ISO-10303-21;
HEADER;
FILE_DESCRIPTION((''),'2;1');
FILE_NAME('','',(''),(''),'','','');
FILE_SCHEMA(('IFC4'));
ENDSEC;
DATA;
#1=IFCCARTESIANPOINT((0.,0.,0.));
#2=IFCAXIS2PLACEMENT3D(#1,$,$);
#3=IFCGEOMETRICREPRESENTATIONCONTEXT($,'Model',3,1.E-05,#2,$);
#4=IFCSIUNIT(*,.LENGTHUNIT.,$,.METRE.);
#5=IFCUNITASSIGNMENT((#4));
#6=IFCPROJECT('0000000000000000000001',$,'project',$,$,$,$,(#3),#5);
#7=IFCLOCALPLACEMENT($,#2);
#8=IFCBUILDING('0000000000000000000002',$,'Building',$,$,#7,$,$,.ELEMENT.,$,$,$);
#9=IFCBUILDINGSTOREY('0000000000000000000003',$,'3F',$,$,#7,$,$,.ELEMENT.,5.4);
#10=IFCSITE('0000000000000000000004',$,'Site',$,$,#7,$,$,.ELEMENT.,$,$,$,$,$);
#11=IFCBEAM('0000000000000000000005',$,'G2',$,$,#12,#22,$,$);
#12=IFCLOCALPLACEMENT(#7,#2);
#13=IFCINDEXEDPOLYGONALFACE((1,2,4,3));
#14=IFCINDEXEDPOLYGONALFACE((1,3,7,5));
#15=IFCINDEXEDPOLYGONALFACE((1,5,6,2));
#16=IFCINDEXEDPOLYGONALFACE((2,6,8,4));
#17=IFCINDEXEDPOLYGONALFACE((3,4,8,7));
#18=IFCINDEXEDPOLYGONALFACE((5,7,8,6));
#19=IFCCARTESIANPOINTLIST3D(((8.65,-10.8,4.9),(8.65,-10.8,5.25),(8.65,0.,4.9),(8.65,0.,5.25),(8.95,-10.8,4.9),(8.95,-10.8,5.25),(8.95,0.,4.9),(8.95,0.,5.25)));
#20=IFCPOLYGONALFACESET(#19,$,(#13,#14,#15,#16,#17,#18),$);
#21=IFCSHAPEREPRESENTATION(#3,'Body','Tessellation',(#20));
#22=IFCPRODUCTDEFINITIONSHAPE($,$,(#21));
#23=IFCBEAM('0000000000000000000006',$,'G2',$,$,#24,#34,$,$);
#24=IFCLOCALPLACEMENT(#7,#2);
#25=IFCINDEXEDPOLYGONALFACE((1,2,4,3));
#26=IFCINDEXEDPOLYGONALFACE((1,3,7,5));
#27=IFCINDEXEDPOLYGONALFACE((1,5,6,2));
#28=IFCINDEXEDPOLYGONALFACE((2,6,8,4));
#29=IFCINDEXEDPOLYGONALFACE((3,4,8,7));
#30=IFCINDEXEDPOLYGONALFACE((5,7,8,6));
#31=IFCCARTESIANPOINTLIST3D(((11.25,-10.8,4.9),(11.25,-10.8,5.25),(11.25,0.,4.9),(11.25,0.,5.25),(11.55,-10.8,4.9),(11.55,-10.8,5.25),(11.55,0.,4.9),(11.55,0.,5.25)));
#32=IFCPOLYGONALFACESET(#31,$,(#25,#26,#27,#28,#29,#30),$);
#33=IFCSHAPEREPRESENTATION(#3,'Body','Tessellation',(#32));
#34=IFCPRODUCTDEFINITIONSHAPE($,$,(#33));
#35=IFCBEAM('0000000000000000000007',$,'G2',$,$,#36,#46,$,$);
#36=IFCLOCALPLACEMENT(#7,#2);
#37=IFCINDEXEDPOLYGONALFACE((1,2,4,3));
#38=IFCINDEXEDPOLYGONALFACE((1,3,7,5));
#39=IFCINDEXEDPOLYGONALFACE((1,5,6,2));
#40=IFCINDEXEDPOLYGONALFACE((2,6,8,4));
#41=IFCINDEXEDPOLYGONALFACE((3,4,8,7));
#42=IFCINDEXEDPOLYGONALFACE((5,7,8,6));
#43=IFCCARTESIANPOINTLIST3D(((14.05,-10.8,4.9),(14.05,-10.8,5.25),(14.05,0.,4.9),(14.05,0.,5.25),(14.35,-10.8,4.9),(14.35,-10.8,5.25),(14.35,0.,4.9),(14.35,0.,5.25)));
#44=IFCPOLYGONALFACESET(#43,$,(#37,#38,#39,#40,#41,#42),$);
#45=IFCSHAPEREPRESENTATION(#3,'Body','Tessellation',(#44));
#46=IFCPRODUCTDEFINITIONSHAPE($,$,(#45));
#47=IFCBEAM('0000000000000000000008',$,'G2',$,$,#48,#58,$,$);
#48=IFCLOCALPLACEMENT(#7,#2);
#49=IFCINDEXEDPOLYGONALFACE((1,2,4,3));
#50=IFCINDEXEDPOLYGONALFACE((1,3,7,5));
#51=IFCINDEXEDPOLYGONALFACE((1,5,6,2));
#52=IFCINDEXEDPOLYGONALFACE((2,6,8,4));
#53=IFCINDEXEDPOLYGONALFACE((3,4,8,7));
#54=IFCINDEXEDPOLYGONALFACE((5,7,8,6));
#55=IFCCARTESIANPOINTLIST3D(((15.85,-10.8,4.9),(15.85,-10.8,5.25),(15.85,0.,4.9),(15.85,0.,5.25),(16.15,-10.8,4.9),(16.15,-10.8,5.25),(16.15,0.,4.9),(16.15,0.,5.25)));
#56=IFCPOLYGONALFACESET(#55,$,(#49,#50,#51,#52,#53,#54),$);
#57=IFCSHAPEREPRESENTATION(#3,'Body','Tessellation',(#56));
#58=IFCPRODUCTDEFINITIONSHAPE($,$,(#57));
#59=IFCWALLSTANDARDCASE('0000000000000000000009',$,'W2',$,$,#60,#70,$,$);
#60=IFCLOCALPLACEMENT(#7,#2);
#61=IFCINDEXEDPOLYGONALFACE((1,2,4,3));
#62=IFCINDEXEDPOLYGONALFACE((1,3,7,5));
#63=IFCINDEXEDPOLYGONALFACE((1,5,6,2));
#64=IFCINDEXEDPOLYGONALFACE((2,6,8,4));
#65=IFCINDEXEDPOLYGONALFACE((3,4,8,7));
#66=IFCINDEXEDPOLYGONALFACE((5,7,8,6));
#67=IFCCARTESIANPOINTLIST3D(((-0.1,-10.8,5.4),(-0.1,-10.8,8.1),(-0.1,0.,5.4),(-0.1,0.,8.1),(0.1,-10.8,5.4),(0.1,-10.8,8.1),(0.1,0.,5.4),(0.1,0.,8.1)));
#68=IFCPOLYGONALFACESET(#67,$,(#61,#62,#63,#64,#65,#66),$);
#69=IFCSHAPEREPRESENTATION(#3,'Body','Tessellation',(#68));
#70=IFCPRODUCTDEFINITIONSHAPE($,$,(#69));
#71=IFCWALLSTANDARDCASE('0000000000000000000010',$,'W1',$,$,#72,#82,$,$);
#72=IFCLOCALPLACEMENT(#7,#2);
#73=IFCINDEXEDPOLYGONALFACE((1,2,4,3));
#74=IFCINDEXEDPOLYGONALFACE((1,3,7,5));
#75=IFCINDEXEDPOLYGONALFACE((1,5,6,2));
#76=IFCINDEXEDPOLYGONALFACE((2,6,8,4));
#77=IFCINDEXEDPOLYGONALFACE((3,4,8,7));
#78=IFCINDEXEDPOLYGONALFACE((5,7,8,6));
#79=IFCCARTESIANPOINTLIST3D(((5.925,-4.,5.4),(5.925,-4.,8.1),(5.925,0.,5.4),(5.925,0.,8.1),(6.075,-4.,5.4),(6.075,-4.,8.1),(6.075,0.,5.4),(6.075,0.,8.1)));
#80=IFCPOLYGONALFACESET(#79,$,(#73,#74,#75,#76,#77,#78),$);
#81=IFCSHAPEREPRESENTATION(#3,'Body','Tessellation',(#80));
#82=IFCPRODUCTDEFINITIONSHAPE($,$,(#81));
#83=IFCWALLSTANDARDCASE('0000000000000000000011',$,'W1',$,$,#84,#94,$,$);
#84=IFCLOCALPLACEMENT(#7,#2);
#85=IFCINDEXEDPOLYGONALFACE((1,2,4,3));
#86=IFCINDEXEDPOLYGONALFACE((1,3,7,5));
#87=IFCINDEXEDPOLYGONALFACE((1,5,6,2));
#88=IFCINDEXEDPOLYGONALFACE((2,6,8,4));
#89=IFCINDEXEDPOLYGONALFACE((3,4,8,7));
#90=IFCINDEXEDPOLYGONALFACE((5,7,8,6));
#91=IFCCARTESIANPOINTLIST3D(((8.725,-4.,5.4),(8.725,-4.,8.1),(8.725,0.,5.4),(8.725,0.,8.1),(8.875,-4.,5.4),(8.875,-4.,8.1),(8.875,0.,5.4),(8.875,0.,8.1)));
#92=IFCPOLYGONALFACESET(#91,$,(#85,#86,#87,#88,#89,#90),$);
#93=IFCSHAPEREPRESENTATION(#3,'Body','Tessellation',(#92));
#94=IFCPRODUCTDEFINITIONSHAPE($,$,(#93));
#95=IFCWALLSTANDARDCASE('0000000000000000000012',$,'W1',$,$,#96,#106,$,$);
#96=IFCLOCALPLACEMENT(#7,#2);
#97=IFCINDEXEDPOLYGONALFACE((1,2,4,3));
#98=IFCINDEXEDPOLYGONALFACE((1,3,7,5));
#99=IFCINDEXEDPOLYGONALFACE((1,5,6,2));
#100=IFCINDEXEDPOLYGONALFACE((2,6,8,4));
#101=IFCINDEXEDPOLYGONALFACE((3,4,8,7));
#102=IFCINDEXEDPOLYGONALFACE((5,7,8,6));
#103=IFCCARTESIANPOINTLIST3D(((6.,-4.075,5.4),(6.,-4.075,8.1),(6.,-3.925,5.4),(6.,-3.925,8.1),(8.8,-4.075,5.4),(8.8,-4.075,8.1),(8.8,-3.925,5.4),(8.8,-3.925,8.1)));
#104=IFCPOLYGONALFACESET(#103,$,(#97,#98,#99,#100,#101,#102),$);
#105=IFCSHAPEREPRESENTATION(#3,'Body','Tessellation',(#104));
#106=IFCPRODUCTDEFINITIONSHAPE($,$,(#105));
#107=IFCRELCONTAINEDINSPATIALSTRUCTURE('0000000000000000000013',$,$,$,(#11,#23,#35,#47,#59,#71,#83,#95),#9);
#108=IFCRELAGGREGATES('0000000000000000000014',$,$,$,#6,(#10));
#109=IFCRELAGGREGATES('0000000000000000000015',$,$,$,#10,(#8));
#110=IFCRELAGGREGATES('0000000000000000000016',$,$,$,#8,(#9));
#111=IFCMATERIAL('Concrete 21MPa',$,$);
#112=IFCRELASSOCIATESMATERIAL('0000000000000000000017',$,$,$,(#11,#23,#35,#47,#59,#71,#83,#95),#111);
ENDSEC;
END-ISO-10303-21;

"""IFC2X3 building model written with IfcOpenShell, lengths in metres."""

from ifc_helpers import new_model, si_unit, frame, origin, origin_2d, place, context, project, spatial, rectangle, extrude, material, element, save


model = new_model("IFC2X3")

# Units and contexts
model_context = context("Model", 3, precision=1e-05, world=origin())
ifc_project = project(units=[si_unit("LENGTHUNIT", "METRE")], contexts=[model_context])

# Site, building, storey
placement = place(None, origin())
site = spatial("IfcSite", under=ifc_project, at=placement, Name="Site", CompositionType="ELEMENT")
building = spatial("IfcBuilding", under=site, at=placement, Name="Building", CompositionType="ELEMENT")
storey = spatial("IfcBuildingStorey", under=building, at=placement, Name="3F", CompositionType="ELEMENT", Elevation=5.4)

# Shared definitions
ifc_material = material(Name="Concrete 21MPa")

# Beams
for number, where, name in (
    (1, (8.8, -5.4, 4.9), "G2"),
    (2, (11.4, -5.4, 4.9), "G2"),
    (3, (14.2, -5.4, 4.9), "G2"),
    (4, (16.0, -5.4, 4.9), "G2"),
):
    element("IfcBeam", number, at=place(None, frame(where)), inside=storey, material=ifc_material, Name=name, context=model_context, shape_type="SweptSolid", body=[
        extrude(rectangle(XDim=0.3, YDim=10.8, at=origin_2d()), origin(), (0.0, 0.0, 1.0), 0.35),
    ])

# Walls
wall_1_placement = place(None, frame((0.0, -5.4, 5.4)))
element("IfcWallStandardCase", 5, at=wall_1_placement, inside=storey, material=ifc_material, Name="W2", context=model_context, shape_type="SweptSolid", body=[
    extrude(rectangle(XDim=0.2, YDim=10.8, at=origin_2d()), origin(), (0.0, 0.0, 1.0), 2.7),
])
for number, where, name in (
    (6, (6.0, -2.0, 5.4), "W1"),
    (7, (8.8, -2.0, 5.4), "W1"),
):
    element("IfcWallStandardCase", number, at=place(None, frame(where)), inside=storey, material=ifc_material, Name=name, context=model_context, shape_type="SweptSolid", body=[
        extrude(rectangle(XDim=0.15, YDim=4.0, at=origin_2d()), origin(), (0.0, 0.0, 1.0), 2.7),
    ])
wall_2_placement = place(None, frame((7.4, -4.0, 5.4)))
element("IfcWallStandardCase", 8, at=wall_2_placement, inside=storey, material=ifc_material, Name="W1", context=model_context, shape_type="SweptSolid", body=[
    extrude(rectangle(XDim=2.8, YDim=0.15, at=origin_2d()), origin(), (0.0, 0.0, 1.0), 2.7),
])

save(model, "model.ifc")
